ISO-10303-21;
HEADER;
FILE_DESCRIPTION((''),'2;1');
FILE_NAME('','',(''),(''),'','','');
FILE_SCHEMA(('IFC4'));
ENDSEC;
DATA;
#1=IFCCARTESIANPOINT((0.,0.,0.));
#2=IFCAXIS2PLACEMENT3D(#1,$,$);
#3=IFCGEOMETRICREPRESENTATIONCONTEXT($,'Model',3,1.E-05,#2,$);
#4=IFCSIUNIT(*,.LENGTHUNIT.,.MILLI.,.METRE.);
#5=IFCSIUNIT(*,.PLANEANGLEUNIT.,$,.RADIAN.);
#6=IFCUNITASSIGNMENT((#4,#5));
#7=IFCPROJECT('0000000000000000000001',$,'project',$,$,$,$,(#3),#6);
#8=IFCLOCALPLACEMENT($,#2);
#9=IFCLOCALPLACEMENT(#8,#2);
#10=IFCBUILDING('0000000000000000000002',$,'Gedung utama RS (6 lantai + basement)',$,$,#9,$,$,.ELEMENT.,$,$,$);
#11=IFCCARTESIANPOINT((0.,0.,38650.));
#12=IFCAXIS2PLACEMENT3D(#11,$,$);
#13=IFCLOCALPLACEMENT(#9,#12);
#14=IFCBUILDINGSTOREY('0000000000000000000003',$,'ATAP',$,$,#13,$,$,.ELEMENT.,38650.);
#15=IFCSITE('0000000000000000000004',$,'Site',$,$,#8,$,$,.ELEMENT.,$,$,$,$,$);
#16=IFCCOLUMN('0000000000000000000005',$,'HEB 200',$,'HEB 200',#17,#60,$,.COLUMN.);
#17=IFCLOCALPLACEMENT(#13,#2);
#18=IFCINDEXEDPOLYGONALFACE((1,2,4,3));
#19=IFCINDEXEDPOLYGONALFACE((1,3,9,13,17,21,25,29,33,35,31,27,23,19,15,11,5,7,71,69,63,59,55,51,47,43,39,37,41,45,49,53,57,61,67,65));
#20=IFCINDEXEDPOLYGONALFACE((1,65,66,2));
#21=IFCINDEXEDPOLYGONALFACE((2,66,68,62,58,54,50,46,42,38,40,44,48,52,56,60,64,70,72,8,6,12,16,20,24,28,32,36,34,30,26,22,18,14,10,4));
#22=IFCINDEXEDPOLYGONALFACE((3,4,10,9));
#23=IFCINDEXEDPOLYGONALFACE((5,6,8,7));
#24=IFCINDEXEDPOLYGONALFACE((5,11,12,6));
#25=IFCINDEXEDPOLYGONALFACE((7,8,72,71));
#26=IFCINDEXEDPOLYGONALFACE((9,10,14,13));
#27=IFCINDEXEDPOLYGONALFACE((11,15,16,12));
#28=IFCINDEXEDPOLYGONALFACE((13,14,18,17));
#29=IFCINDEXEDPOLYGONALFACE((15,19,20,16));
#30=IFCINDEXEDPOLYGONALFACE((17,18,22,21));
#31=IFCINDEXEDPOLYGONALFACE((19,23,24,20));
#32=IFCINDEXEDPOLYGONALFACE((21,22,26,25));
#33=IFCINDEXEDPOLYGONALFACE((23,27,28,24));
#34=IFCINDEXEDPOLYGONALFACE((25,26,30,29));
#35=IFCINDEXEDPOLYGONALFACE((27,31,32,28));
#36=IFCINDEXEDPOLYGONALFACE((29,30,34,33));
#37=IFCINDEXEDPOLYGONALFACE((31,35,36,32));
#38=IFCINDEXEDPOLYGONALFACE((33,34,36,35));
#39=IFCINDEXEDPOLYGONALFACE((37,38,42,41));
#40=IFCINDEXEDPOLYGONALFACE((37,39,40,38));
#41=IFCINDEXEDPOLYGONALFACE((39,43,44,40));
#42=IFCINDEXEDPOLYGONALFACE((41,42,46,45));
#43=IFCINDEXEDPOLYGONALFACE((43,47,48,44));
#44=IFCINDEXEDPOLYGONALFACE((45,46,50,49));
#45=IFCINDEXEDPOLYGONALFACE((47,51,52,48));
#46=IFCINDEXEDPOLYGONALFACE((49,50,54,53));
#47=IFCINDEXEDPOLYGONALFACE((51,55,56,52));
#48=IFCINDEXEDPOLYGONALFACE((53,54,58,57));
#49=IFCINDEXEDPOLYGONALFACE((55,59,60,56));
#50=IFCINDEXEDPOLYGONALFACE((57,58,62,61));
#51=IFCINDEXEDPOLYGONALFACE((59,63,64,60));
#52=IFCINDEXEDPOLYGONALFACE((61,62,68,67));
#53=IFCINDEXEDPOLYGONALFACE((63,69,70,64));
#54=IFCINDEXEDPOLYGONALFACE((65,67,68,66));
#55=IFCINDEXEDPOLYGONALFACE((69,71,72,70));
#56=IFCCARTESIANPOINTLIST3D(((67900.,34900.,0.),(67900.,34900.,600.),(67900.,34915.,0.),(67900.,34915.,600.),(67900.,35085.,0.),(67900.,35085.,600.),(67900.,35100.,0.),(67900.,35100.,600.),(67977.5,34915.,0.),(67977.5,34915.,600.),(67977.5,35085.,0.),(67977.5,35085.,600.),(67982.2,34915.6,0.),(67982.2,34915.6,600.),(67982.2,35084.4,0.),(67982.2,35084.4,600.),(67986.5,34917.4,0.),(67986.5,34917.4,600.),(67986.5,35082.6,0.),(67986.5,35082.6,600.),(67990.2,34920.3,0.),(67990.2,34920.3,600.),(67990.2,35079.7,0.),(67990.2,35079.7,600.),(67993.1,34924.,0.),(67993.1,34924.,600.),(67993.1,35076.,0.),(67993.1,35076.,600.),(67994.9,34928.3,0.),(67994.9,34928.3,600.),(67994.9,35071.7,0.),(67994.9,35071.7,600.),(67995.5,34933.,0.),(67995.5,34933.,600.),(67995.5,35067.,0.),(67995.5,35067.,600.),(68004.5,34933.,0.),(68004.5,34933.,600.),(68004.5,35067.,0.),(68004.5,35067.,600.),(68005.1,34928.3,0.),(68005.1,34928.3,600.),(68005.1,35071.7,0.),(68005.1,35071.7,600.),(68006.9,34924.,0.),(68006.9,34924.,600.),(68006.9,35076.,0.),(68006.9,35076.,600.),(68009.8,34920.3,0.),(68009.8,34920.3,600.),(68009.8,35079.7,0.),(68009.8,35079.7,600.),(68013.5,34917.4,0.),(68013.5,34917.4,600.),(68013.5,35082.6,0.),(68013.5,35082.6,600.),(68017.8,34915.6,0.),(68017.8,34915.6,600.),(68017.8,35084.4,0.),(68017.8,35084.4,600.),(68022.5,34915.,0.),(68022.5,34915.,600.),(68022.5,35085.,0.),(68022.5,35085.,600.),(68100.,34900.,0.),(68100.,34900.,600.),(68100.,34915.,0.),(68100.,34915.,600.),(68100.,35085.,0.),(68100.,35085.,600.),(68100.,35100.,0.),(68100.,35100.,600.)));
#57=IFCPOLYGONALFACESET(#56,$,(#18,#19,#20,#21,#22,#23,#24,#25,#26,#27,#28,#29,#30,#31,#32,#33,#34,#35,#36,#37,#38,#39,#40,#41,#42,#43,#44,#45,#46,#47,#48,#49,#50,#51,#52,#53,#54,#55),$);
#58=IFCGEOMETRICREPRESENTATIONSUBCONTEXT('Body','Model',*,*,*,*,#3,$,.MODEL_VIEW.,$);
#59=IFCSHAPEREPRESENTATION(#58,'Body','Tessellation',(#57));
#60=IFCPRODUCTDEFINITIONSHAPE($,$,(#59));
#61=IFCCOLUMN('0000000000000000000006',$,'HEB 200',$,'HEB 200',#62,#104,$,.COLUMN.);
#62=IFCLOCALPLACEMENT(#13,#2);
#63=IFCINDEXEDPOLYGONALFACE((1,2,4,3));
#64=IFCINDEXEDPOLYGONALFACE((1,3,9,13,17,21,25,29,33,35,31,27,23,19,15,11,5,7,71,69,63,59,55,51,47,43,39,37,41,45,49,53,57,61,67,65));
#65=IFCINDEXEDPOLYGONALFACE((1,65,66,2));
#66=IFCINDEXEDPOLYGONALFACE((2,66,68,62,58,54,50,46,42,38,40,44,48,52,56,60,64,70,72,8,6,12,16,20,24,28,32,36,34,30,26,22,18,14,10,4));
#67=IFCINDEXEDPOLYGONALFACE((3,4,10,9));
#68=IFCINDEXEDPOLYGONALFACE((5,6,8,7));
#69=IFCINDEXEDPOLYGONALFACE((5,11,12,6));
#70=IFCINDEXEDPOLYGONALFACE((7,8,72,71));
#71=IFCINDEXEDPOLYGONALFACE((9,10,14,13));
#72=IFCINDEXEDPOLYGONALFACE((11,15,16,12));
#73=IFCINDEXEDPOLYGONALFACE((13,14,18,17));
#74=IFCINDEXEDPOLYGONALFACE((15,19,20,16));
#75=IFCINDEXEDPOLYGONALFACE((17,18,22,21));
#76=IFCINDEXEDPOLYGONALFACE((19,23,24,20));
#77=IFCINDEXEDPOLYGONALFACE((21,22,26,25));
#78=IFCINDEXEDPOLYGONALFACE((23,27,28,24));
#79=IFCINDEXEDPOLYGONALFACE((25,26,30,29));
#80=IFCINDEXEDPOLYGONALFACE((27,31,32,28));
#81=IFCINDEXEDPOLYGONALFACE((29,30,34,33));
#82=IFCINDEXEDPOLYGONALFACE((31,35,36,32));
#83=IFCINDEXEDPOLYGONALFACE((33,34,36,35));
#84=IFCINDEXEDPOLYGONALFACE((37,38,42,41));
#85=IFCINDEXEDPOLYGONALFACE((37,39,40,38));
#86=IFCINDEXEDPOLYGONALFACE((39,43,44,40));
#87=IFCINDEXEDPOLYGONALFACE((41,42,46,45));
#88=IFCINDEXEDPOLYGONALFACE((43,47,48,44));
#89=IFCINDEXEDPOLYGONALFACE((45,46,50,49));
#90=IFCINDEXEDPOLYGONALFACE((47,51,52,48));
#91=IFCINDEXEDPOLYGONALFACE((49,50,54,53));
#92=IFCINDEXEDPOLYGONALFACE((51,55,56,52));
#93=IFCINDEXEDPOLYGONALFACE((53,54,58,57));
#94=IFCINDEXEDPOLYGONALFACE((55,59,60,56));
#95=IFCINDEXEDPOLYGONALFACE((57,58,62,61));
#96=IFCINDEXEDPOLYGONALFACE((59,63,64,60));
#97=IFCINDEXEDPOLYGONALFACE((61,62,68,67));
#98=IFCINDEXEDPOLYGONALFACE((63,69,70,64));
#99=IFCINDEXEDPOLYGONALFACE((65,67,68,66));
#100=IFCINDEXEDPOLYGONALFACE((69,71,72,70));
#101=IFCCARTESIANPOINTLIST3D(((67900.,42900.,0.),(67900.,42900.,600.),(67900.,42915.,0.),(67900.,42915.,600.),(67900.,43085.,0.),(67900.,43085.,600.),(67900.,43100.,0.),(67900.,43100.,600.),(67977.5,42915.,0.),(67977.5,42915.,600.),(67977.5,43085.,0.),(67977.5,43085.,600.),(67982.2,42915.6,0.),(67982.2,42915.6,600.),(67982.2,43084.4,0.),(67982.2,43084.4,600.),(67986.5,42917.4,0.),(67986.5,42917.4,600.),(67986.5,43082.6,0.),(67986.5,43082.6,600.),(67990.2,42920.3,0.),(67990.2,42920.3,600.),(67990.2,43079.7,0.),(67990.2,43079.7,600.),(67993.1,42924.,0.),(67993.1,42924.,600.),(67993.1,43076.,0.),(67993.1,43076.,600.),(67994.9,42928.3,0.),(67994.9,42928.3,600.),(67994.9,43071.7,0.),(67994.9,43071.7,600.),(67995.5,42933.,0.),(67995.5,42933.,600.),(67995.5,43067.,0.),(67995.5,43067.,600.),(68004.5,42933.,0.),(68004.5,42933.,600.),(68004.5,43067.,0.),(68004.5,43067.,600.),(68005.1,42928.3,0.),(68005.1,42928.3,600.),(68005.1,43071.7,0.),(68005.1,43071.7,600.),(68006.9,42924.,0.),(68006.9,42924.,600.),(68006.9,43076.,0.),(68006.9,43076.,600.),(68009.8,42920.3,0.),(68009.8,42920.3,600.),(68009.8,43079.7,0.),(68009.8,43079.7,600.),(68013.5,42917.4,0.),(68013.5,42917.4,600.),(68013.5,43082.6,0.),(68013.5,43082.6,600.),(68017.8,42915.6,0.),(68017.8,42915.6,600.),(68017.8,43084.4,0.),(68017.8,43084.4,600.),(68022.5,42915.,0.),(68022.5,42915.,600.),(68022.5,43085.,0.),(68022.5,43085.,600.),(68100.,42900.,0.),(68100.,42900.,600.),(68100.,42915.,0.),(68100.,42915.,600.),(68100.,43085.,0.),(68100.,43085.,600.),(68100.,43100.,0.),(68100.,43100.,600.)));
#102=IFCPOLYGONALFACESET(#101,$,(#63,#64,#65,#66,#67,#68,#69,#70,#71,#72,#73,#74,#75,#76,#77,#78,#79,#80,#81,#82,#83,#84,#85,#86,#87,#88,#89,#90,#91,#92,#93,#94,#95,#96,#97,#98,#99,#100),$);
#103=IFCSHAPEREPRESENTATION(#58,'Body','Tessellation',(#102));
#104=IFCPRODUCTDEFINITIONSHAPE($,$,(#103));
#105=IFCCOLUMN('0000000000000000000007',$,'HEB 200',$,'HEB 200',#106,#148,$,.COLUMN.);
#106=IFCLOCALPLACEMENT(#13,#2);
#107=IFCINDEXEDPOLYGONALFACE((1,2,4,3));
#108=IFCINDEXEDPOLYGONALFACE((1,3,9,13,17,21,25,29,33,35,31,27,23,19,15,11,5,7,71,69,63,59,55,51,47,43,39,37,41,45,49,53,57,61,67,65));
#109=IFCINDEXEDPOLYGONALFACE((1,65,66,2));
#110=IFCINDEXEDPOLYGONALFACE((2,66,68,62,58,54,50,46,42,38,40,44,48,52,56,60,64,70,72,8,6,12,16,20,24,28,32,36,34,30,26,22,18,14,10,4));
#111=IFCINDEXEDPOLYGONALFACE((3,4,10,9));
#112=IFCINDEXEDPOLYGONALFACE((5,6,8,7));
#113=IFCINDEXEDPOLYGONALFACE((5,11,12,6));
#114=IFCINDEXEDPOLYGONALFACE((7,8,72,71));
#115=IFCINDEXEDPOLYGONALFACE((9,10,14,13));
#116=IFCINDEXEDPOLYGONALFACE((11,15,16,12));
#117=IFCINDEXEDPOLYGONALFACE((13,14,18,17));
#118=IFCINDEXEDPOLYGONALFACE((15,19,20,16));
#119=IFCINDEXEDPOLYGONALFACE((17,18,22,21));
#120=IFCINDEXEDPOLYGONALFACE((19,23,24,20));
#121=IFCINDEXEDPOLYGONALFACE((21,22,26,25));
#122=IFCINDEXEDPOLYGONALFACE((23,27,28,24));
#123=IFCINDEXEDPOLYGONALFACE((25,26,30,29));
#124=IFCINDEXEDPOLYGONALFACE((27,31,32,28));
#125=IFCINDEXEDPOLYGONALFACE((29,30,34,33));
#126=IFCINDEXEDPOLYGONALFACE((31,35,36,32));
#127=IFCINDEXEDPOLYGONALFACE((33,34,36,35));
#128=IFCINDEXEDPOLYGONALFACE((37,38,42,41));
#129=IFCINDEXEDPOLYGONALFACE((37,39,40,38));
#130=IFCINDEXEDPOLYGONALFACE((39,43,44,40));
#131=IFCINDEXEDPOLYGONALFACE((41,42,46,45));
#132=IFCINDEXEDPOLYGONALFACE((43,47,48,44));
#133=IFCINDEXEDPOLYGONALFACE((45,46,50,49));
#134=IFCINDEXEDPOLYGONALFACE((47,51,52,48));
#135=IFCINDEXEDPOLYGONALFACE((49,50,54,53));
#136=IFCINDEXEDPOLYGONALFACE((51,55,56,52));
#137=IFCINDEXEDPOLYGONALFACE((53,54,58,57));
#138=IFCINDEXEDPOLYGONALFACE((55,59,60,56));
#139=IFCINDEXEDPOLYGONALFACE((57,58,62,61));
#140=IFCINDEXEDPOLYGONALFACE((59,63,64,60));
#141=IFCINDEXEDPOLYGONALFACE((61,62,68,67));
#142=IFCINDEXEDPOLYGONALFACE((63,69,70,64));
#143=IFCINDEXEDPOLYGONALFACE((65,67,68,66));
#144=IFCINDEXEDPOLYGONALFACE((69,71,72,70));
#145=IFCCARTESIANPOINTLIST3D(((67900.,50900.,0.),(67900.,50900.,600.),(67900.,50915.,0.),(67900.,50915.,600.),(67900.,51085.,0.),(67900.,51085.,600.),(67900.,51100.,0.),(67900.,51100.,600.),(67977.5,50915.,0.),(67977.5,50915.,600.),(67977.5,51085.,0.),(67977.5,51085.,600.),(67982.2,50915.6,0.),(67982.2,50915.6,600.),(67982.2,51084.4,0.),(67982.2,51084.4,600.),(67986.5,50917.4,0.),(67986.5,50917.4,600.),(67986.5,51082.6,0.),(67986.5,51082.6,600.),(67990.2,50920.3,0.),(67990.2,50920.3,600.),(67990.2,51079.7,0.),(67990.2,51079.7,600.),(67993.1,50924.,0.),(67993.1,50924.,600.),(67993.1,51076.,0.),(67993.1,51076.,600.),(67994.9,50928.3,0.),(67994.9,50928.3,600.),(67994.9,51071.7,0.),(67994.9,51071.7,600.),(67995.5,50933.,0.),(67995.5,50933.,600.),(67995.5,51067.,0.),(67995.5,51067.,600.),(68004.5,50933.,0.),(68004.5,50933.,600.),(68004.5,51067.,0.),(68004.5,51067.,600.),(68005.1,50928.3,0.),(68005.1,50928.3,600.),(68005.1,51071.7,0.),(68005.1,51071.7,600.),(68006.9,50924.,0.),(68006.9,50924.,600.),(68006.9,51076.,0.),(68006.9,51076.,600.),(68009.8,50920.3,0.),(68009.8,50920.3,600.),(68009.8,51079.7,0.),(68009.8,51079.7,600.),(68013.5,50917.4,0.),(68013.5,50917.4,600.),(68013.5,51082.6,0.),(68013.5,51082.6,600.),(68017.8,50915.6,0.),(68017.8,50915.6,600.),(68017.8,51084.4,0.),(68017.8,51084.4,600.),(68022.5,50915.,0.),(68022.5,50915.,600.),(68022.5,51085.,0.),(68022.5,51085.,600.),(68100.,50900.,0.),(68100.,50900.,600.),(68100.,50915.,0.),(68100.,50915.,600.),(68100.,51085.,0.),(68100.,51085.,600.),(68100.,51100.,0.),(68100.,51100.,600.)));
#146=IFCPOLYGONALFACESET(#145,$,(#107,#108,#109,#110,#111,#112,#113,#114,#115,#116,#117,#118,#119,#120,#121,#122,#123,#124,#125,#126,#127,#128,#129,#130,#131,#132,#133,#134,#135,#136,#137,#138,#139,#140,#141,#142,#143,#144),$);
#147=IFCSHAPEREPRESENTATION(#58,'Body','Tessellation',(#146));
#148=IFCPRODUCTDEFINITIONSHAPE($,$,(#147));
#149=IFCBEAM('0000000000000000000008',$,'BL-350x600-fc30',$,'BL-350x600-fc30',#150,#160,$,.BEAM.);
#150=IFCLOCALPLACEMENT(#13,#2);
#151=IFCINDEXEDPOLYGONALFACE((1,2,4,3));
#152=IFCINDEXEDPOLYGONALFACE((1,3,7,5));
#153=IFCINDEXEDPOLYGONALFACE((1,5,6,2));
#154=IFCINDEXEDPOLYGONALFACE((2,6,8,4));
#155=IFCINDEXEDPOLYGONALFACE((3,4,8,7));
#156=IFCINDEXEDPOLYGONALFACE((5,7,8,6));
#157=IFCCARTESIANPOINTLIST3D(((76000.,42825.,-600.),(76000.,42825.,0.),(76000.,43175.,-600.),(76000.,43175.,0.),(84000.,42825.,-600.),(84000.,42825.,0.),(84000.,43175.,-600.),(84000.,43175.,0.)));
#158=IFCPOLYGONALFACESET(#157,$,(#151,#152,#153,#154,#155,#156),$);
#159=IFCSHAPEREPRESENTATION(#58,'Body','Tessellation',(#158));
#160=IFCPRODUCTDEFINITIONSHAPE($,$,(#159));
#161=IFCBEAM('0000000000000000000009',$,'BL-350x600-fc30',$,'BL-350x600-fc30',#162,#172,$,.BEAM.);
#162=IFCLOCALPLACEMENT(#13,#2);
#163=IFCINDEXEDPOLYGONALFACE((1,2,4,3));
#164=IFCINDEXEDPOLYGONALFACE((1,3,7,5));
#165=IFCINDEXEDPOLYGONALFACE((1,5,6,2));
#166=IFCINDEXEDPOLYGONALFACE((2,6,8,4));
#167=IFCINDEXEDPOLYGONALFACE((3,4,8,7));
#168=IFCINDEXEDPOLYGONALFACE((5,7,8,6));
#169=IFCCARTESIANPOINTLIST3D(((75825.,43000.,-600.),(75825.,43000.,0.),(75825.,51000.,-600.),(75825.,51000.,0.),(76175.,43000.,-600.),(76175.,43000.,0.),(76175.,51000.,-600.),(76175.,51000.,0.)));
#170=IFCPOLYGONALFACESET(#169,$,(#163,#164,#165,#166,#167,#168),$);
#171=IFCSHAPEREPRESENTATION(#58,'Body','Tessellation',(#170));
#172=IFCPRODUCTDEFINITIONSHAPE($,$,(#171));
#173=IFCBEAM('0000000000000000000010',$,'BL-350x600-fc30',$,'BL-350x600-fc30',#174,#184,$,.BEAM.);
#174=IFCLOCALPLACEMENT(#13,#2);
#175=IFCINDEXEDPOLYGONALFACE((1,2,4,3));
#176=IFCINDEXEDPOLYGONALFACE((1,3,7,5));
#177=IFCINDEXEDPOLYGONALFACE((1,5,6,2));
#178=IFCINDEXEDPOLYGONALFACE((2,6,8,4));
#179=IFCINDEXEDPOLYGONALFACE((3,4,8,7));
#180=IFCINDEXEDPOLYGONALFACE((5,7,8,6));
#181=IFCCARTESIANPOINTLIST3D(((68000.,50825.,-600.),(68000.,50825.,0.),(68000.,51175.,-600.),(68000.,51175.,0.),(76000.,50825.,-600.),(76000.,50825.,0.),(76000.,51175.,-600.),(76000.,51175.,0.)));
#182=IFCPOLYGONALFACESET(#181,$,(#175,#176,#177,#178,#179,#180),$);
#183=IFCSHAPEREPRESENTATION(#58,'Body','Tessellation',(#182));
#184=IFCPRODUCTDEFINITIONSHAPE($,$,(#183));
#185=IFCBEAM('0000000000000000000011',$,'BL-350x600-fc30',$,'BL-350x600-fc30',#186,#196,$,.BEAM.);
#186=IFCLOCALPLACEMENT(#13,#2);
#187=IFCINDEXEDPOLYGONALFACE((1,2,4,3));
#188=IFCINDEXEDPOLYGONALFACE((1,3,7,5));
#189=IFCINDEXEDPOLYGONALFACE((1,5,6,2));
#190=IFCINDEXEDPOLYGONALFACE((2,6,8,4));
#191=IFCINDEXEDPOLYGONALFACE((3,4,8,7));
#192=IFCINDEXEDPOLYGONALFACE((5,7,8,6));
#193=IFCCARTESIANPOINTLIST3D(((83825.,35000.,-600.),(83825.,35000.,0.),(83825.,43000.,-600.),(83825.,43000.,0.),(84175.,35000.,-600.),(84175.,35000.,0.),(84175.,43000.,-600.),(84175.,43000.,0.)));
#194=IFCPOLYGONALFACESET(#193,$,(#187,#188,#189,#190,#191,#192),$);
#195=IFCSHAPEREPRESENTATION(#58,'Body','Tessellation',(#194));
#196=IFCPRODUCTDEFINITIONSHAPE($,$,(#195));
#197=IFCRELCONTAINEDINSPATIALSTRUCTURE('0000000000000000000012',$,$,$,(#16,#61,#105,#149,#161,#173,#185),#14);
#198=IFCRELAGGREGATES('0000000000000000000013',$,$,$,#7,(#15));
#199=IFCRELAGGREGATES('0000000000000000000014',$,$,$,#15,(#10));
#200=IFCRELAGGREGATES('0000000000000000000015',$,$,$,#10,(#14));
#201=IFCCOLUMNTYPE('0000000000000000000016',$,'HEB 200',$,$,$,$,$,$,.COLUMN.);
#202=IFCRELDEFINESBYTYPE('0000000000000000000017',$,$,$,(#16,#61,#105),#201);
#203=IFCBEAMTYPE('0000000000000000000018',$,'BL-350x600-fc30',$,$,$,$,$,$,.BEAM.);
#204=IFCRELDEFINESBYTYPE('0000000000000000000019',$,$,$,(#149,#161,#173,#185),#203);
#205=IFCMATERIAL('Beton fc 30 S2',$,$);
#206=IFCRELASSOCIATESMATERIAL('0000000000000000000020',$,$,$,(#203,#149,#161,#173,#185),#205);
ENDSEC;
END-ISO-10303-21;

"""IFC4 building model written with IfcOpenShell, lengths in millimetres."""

from ifc_helpers import new_model, si_unit, frame, origin, origin_2d, place, context, subcontext, project, spatial, rectangle, i_section, extrude, material, material_profile, profile_set, profile_usage, type_object, element, save


model = new_model("IFC4")

# Units and contexts
model_context = context("Model", 3, precision=1e-05, world=origin())
body_context = subcontext(model_context, "Body", "Model", "MODEL_VIEW")
ifc_project = project(units=[si_unit("LENGTHUNIT", "METRE", prefix="MILLI"), si_unit("PLANEANGLEUNIT", "RADIAN")], contexts=[model_context])

# Site, building, storey
site_placement = place(None, origin())
site = spatial("IfcSite", under=ifc_project, at=site_placement, Name="Site", CompositionType="ELEMENT")
building_placement = place(site_placement, origin())
building = spatial("IfcBuilding", under=site, at=building_placement, Name="Gedung utama RS (6 lantai + basement)", CompositionType="ELEMENT")
storey_placement = place(building_placement, frame((0.0, 0.0, 38650.0)))
storey = spatial("IfcBuildingStorey", under=building, at=storey_placement, Name="ATAP", CompositionType="ELEMENT", Elevation=38650.0)

# Columns
ifc_material_profile_1 = material_profile(None, i_section(OverallWidth=200.0, OverallDepth=200.0, WebThickness=9.0, FlangeThickness=15.0, FilletRadius=18.0, at=origin_2d()), Name="HEB 200")
ifc_profile_set_1 = profile_set([ifc_material_profile_1], Name="HEB 200")
ifc_profile_usage_1 = profile_usage(ifc_profile_set_1, cardinal=5)
column_type = type_object("IfcColumnType", Name="HEB 200", PredefinedType="COLUMN", material=ifc_profile_set_1)
for number, where, z_axis, x_axis, name in (
    (1, (68000.0, 35000.0, 0.0), (0.0, 0.0, 1.0), (1.0, 0.0, 0.0), "HEB 200"),
    (2, (68000.0, 43000.0, 0.0), (0.0, 0.0, 1.0), (1.0, 0.0, 0.0), "HEB 200"),
    (3, (68000.0, 51000.0, 0.0), (0.0, 0.0, 1.0), (1.0, 0.0, 0.0), "HEB 200"),
):
    element("IfcColumn", number, at=place(storey_placement, frame(where, z_axis=z_axis, x_axis=x_axis)), inside=storey, type_object=column_type, material=ifc_profile_usage_1, Name=name, ObjectType="HEB 200", PredefinedType="COLUMN", context=body_context, shape_type="SweptSolid", body=[
        extrude(i_section(OverallWidth=200.0, OverallDepth=200.0, WebThickness=9.0, FlangeThickness=15.0, FilletRadius=18.0, at=origin_2d()), origin(), (0.0, 0.0, 1.0), 600.0),
    ])

# Beams
ifc_material = material(Name="Beton fc 30 S2")
ifc_material_profile_2 = material_profile(ifc_material, rectangle(XDim=350.0, YDim=600.0, at=origin_2d()), Name="BL-350x600-fc30")
ifc_profile_set_2 = profile_set([ifc_material_profile_2], Name="BL-350x600-fc30")
ifc_profile_usage_2 = profile_usage(ifc_profile_set_2, cardinal=8)
beam_type = type_object("IfcBeamType", Name="BL-350x600-fc30", PredefinedType="BEAM", material=ifc_profile_set_2)
beam_1_placement = place(storey_placement, frame((76000.0, 43000.0, -300.0)))
element("IfcBeam", 4, at=beam_1_placement, inside=storey, type_object=beam_type, material=ifc_profile_usage_2, Name="BL-350x600-fc30", ObjectType="BL-350x600-fc30", PredefinedType="BEAM", context=body_context, shape_type="SweptSolid", body=[
    extrude(rectangle(XDim=350.0, YDim=600.0, at=origin_2d()), frame((0.0, 0.0, 0.0), z_axis=(1.0, 0.0, 0.0), x_axis=(0.0, 1.0, 0.0)), (0.0, 0.0, 1.0), 8000.0),
])
beam_2_placement = place(storey_placement, frame((76000.0, 43000.0, -300.0)))
element("IfcBeam", 5, at=beam_2_placement, inside=storey, type_object=beam_type, material=ifc_profile_usage_2, Name="BL-350x600-fc30", ObjectType="BL-350x600-fc30", PredefinedType="BEAM", context=body_context, shape_type="SweptSolid", body=[
    extrude(rectangle(XDim=350.0, YDim=600.0, at=origin_2d()), frame((0.0, 0.0, 0.0), z_axis=(0.0, 1.0, 0.0), x_axis=(-1.0, 0.0, 0.0)), (0.0, 0.0, 1.0), 8000.0),
])
beam_3_placement = place(storey_placement, frame((68000.0, 51000.0, -300.0)))
element("IfcBeam", 6, at=beam_3_placement, inside=storey, type_object=beam_type, material=ifc_profile_usage_2, Name="BL-350x600-fc30", ObjectType="BL-350x600-fc30", PredefinedType="BEAM", context=body_context, shape_type="SweptSolid", body=[
    extrude(rectangle(XDim=350.0, YDim=600.0, at=origin_2d()), frame((0.0, 0.0, 0.0), z_axis=(1.0, 0.0, 0.0), x_axis=(0.0, 1.0, 0.0)), (0.0, 0.0, 1.0), 8000.0),
])
beam_4_placement = place(storey_placement, frame((84000.0, 35000.0, -300.0)))
element("IfcBeam", 7, at=beam_4_placement, inside=storey, type_object=beam_type, material=ifc_profile_usage_2, Name="BL-350x600-fc30", ObjectType="BL-350x600-fc30", PredefinedType="BEAM", context=body_context, shape_type="SweptSolid", body=[
    extrude(rectangle(XDim=350.0, YDim=600.0, at=origin_2d()), frame((0.0, 0.0, 0.0), z_axis=(0.0, 1.0, 0.0), x_axis=(-1.0, 0.0, 0.0)), (0.0, 0.0, 1.0), 8000.0),
])

save(model, "model.ifc")
